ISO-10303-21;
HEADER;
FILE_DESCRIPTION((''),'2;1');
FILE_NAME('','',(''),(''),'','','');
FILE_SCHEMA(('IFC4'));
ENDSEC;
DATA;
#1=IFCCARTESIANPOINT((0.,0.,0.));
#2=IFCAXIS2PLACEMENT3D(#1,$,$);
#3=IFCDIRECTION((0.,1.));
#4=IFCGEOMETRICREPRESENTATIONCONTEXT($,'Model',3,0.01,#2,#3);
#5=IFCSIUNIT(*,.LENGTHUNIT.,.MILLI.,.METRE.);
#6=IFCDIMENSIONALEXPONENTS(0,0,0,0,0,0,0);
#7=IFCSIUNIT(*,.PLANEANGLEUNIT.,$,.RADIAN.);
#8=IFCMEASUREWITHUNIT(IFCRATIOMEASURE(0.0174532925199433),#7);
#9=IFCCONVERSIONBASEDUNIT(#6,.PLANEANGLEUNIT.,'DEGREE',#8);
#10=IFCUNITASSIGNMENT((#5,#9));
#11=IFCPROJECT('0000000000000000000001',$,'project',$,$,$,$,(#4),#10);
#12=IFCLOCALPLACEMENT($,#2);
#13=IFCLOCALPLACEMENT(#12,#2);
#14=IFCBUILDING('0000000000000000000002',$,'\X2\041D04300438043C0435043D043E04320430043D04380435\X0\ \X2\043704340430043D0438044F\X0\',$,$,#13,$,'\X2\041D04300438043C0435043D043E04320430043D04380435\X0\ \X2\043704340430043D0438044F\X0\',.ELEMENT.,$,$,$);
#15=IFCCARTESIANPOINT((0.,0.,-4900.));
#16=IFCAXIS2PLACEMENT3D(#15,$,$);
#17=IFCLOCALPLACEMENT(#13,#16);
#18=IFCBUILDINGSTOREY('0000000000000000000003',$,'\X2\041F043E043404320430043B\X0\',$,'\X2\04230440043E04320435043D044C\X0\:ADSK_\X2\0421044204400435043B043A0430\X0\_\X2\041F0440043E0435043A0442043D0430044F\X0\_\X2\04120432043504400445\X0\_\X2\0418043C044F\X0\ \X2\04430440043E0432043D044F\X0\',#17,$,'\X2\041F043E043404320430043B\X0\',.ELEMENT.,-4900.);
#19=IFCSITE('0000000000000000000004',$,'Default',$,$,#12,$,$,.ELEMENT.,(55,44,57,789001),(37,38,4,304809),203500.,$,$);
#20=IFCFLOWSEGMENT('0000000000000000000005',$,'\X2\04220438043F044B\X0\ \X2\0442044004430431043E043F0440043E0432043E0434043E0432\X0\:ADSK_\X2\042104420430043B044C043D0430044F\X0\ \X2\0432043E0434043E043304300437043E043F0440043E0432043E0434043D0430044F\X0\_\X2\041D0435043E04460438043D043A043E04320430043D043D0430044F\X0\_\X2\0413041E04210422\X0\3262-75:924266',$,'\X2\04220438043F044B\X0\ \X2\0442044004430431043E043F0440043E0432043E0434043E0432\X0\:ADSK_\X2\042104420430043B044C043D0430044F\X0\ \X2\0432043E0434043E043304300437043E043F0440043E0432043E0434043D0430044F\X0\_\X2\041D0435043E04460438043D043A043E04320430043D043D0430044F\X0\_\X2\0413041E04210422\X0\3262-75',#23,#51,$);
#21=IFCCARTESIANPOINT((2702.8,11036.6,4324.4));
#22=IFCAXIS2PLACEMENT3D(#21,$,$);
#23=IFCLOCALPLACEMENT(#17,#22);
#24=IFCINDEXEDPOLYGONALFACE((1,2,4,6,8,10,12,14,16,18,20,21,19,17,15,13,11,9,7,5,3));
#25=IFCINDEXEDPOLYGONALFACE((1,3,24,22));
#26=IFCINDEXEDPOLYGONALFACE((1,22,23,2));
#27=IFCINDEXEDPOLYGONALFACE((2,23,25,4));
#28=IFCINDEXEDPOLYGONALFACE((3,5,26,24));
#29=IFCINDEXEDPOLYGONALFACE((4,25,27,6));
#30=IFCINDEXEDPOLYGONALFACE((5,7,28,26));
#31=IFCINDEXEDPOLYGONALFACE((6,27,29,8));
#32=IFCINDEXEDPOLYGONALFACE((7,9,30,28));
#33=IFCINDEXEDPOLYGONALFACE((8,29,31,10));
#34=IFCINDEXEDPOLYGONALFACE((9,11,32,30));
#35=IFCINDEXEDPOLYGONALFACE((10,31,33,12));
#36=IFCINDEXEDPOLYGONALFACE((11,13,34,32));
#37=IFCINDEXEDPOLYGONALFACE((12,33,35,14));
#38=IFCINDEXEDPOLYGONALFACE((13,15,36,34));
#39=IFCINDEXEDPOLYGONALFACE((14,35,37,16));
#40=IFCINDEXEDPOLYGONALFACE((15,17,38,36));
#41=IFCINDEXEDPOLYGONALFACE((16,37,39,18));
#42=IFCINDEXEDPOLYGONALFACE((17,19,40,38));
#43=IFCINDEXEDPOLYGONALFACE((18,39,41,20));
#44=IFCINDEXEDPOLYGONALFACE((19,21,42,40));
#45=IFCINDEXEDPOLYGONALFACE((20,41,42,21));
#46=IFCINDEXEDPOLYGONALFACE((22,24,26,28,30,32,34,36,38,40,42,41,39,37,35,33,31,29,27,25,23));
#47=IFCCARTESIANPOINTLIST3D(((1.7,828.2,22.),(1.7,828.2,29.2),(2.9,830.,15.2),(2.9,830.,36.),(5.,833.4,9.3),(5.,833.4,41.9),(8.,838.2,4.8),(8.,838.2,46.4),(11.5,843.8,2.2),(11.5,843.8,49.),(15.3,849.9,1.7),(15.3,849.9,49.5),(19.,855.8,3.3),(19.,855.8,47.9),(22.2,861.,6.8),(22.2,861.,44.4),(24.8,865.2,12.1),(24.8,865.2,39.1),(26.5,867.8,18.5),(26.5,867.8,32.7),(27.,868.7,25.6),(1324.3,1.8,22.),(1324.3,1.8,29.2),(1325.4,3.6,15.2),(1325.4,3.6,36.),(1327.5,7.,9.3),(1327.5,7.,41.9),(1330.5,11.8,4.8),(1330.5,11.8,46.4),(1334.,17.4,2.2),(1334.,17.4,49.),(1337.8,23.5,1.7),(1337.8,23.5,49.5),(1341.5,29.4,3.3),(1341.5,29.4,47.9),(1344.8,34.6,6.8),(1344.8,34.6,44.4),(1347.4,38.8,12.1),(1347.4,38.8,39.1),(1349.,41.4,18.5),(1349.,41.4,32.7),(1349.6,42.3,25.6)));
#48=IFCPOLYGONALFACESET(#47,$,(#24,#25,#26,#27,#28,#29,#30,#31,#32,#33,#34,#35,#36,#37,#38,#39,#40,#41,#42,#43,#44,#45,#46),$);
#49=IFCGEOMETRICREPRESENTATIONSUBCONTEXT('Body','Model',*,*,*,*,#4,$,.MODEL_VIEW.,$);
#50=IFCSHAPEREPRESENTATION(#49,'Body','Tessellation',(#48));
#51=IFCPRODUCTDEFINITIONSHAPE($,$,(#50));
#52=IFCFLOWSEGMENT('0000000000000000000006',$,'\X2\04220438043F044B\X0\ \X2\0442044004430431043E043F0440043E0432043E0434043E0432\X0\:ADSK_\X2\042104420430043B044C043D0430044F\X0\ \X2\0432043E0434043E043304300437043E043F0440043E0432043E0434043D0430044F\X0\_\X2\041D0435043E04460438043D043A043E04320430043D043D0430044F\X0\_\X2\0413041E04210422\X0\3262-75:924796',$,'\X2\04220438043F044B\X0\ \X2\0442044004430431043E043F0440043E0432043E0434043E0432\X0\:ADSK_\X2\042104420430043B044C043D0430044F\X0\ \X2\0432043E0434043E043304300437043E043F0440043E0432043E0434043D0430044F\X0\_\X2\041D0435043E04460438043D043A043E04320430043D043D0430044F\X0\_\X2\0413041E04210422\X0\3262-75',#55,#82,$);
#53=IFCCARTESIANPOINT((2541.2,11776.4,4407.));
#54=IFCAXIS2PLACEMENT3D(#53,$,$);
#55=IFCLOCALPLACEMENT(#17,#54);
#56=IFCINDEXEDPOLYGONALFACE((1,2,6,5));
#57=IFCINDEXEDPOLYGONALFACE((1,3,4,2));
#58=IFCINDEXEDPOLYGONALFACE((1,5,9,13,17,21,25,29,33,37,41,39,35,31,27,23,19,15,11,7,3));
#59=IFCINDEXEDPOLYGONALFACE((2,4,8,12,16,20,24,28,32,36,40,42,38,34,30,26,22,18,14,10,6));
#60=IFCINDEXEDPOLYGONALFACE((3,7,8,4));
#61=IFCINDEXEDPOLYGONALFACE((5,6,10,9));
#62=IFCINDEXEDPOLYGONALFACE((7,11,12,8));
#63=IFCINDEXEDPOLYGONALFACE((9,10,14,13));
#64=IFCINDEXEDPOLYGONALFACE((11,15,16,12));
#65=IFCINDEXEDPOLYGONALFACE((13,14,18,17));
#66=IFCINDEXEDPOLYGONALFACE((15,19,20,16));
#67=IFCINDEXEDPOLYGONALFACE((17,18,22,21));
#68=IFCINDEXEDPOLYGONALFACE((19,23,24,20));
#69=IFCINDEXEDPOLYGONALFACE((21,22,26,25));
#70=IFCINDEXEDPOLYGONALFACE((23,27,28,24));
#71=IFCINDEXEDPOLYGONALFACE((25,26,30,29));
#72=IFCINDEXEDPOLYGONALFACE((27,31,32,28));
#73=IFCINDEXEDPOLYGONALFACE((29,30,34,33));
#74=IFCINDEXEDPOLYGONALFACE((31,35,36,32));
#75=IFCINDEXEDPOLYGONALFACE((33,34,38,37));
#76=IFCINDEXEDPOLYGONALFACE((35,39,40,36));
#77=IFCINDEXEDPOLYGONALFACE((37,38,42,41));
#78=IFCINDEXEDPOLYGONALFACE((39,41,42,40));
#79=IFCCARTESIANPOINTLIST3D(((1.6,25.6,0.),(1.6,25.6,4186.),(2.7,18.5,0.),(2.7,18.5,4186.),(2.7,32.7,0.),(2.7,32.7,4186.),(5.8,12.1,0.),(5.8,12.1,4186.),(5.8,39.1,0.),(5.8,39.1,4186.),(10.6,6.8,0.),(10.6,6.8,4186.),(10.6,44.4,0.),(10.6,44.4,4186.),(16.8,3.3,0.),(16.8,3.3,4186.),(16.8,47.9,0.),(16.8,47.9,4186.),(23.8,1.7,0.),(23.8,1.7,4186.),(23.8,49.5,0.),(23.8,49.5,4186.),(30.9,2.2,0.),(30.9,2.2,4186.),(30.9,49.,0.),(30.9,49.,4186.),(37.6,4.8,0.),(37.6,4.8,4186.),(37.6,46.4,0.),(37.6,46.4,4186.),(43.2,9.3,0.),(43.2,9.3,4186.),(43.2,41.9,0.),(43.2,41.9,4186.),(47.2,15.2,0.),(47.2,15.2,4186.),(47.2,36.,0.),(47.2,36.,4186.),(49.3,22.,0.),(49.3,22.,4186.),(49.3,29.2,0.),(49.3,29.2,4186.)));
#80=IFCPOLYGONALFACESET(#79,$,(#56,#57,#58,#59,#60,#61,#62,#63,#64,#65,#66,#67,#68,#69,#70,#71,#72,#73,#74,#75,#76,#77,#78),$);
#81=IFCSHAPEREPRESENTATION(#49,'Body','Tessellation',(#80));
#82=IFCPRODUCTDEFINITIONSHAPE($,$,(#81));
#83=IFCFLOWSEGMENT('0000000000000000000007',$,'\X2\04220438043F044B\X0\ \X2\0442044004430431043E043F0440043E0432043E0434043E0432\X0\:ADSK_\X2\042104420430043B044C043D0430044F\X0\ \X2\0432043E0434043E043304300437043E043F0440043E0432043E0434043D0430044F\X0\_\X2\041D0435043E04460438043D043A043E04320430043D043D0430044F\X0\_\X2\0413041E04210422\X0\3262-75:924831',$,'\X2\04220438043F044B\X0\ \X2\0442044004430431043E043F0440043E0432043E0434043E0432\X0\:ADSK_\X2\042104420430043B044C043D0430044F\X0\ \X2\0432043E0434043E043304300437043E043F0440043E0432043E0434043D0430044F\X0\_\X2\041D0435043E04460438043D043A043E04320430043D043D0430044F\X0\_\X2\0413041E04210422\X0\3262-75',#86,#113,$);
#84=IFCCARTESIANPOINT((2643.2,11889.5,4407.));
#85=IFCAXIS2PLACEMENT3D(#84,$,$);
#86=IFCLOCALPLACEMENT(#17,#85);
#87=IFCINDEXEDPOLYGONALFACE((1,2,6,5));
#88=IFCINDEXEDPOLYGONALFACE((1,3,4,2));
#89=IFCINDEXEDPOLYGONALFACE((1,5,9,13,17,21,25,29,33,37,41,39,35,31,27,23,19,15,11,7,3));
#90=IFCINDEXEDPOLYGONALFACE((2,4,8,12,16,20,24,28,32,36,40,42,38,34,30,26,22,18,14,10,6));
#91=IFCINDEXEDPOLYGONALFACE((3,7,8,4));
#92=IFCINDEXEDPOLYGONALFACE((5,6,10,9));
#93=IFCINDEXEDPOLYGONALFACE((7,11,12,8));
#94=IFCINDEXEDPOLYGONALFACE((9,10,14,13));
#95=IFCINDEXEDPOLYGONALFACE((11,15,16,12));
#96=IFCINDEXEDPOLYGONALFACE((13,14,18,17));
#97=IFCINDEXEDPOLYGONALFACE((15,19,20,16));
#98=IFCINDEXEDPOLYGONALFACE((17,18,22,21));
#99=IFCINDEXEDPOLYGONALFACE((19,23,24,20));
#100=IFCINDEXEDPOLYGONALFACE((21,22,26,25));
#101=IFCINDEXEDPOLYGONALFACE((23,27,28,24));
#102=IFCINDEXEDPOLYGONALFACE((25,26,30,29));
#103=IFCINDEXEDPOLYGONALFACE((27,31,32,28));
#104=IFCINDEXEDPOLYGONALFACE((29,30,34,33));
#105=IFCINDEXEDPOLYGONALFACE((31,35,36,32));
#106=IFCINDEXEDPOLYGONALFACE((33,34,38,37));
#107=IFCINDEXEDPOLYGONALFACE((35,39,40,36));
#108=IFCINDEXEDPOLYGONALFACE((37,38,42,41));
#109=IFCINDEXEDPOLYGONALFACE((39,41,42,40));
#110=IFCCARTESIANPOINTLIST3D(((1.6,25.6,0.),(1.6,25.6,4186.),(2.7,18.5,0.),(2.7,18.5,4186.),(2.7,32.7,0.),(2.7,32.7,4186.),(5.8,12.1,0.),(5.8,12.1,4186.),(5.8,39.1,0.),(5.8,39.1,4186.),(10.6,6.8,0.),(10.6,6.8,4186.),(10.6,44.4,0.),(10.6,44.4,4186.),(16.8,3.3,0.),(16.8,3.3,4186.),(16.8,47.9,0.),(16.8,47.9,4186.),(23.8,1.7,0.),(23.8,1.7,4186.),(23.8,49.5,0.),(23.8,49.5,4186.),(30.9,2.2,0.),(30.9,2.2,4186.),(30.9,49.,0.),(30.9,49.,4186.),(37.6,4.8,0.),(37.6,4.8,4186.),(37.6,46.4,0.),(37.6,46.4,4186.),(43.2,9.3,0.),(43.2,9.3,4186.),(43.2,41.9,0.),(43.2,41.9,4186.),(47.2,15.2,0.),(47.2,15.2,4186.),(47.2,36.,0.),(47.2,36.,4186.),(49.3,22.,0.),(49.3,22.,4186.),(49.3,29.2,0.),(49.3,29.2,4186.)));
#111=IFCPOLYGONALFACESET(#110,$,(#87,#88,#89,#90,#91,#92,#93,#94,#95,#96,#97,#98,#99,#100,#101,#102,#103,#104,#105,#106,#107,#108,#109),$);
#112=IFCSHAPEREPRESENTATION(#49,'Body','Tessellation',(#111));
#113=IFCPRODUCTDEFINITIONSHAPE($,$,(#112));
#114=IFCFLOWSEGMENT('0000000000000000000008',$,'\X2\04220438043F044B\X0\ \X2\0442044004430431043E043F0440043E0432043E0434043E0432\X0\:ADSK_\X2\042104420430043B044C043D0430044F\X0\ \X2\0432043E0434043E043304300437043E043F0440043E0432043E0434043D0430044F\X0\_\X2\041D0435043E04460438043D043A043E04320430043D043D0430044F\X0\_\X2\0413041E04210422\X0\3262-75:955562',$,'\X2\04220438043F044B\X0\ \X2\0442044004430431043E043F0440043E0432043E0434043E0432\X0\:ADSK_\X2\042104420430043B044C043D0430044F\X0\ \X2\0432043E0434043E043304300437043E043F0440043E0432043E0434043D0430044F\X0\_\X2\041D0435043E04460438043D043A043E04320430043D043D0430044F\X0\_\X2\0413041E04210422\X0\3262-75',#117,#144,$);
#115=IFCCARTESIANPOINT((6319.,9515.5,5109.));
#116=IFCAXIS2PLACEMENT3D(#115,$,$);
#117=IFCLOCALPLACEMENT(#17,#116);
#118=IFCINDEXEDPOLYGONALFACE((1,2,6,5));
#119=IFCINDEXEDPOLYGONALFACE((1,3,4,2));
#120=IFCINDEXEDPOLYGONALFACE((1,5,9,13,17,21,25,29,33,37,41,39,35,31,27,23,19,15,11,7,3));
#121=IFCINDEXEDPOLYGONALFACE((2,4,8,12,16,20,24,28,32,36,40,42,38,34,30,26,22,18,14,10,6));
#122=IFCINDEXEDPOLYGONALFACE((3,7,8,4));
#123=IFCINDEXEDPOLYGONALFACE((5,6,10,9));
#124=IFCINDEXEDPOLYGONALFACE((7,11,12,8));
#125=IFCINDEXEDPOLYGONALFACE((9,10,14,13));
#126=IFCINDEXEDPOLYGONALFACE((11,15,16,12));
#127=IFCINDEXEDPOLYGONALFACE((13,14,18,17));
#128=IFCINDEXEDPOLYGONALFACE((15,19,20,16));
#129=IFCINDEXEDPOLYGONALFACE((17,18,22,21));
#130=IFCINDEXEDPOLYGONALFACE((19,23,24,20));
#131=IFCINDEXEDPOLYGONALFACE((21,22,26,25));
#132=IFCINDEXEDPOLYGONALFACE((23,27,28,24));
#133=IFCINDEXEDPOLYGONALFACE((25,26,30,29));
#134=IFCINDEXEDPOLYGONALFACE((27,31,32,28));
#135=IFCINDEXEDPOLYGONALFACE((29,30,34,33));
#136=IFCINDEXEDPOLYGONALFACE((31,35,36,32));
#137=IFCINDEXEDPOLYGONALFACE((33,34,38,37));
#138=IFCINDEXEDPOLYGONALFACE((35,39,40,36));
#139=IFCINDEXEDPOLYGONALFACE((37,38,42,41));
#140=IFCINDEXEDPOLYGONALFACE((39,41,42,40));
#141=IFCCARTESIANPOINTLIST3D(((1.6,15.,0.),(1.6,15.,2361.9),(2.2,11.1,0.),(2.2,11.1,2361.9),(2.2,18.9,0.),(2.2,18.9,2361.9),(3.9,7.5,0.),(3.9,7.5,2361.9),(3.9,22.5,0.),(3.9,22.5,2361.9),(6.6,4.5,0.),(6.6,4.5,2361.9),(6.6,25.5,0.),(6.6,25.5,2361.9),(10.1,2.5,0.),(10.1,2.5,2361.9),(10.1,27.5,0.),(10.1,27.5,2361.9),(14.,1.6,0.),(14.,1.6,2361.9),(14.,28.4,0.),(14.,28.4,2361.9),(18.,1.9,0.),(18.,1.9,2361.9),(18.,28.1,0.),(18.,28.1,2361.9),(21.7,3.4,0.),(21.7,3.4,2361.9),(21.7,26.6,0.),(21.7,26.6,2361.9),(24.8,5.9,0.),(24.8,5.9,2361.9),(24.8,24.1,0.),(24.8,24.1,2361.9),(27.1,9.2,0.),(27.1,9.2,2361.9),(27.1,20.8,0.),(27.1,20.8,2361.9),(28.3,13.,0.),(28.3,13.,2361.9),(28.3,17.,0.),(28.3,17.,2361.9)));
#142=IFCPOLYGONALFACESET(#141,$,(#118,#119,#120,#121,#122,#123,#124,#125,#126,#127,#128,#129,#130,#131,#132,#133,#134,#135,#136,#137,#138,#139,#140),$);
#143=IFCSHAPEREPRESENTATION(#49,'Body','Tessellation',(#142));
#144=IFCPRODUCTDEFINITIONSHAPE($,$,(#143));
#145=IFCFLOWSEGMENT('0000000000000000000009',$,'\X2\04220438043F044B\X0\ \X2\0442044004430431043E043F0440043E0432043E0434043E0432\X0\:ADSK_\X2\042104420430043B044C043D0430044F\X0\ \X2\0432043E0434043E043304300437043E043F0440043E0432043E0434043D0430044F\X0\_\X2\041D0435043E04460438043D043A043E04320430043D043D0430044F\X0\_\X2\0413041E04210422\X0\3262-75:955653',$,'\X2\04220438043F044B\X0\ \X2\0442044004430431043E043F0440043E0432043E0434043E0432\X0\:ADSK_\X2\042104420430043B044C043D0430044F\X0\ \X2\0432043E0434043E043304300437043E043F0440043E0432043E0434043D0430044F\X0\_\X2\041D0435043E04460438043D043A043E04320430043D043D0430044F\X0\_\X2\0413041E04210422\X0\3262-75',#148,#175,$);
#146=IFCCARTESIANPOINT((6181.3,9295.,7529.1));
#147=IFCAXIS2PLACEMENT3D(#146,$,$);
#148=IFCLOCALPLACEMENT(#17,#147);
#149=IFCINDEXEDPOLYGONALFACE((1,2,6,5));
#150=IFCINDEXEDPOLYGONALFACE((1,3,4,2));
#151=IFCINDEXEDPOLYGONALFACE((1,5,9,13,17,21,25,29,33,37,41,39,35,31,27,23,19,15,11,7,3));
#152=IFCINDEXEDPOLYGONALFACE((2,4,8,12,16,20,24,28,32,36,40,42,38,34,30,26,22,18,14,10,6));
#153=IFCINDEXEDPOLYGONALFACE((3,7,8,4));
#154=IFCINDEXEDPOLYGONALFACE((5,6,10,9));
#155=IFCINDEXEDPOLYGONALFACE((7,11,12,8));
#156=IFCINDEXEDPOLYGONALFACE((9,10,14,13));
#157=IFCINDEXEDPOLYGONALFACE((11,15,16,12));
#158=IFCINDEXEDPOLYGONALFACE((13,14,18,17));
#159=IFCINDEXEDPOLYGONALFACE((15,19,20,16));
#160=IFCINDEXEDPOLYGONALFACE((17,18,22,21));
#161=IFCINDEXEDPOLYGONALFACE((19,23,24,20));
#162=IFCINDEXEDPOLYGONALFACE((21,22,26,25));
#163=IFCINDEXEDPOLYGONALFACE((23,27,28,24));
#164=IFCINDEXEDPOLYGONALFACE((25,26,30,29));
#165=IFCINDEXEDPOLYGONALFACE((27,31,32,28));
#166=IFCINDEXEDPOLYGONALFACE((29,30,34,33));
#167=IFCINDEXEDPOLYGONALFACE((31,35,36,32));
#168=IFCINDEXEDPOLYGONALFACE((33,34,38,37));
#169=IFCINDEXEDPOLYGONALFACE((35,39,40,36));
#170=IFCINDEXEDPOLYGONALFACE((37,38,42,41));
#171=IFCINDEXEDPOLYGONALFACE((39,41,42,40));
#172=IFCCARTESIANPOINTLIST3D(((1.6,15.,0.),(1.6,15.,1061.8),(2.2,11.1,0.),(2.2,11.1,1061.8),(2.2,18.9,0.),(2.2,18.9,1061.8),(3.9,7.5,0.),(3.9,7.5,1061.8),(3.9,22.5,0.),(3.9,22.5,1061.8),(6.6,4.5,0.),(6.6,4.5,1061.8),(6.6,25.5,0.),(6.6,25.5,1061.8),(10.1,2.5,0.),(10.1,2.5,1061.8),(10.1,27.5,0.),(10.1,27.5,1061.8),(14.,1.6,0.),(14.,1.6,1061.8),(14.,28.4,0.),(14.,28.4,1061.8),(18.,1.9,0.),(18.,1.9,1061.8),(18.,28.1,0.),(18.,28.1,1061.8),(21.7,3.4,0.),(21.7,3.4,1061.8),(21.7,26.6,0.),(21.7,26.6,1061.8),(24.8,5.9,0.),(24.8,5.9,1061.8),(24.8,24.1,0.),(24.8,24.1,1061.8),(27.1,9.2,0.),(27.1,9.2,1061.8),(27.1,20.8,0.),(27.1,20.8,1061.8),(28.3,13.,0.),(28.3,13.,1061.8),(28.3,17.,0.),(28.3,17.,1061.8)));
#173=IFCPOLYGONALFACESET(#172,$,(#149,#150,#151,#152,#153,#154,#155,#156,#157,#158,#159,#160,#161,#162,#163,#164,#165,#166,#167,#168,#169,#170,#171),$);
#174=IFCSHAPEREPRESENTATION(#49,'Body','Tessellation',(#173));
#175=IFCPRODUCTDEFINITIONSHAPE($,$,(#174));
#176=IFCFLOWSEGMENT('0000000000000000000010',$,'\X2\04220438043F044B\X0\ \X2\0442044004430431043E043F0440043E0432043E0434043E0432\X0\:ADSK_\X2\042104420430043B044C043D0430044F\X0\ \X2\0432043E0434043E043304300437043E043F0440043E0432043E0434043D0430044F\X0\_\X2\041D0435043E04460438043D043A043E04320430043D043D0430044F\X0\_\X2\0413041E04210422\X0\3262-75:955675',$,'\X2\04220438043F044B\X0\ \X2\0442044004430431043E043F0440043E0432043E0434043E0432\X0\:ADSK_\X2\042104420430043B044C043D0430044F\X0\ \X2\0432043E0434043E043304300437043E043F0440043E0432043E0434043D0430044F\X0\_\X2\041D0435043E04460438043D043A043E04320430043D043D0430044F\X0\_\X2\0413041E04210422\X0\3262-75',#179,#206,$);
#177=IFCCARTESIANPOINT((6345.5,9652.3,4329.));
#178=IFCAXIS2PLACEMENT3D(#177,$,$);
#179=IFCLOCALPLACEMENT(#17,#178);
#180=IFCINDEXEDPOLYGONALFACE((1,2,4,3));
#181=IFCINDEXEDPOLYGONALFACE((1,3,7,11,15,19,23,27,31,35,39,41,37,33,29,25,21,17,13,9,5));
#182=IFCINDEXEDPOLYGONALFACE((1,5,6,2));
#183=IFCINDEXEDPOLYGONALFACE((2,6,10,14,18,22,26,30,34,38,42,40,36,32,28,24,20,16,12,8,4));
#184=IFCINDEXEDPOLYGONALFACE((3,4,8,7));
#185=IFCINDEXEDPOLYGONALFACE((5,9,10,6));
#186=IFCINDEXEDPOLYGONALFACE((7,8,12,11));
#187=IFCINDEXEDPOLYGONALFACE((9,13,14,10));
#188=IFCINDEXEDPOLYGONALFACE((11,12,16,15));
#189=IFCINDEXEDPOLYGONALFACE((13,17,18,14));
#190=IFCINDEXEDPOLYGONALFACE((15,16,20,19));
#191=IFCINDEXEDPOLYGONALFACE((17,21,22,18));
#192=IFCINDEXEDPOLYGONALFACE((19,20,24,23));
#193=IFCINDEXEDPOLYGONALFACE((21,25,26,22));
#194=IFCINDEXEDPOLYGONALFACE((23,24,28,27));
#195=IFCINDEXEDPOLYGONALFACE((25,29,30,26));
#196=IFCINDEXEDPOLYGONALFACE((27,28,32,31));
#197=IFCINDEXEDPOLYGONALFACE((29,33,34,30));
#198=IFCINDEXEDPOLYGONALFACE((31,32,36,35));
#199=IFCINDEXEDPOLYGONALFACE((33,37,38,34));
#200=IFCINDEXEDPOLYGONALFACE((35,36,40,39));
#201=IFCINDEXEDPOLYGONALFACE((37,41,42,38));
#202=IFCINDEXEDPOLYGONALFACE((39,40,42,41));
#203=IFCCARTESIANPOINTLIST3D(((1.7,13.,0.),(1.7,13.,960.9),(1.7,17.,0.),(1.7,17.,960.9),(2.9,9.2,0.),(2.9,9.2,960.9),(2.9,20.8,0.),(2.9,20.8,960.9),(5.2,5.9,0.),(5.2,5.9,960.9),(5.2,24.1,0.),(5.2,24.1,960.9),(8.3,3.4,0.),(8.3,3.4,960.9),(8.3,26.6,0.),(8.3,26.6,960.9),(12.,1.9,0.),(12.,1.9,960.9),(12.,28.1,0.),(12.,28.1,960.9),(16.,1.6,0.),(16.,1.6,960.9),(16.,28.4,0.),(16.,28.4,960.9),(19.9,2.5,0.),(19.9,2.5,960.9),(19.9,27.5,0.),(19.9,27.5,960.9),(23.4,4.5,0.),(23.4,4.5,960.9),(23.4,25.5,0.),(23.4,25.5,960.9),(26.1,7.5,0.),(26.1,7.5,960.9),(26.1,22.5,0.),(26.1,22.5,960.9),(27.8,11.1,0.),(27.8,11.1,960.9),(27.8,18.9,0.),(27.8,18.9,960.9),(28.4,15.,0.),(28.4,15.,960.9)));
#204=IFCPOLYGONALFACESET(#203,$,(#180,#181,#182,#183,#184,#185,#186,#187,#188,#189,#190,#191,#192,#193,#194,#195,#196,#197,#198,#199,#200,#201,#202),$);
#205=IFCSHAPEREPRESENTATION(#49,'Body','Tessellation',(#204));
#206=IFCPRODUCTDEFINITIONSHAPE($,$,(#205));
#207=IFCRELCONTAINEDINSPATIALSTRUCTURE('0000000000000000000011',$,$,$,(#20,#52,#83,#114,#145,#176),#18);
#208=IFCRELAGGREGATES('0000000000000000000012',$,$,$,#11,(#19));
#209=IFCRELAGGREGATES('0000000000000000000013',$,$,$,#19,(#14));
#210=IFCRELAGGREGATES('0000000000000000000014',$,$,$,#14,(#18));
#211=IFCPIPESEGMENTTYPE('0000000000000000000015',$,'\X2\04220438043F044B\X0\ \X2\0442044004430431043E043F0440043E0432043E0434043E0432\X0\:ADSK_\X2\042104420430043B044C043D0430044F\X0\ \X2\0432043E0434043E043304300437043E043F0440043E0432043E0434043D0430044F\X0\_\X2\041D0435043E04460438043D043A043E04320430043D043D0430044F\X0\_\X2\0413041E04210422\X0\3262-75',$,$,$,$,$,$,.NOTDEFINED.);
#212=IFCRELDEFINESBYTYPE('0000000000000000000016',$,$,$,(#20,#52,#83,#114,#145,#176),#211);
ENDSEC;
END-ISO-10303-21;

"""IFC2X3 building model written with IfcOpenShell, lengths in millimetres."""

from ifc_helpers import new_model, entity, si_unit, converted_unit, direction, frame, origin, origin_2d_with_axis, place, context, subcontext, project, spatial, circle, extrude, type_object, element, save


model = new_model("IFC2X3")

# Units and contexts
model_context = context("Model", 3, precision=0.01, world=origin(), true_north=direction((0.0, 1.0)))
body_context = subcontext(model_context, "Body", "Model", "MODEL_VIEW")
ifc_project = project(units=[si_unit("LENGTHUNIT", "METRE", prefix="MILLI"), converted_unit("PLANEANGLEUNIT", "DEGREE", entity("IfcRatioMeasure", 0.0174532925199433), si_unit("PLANEANGLEUNIT", "RADIAN"), dimensions=[0, 0, 0, 0, 0, 0, 0])], contexts=[model_context])

# Site, building, storey
site_placement = place(None, origin())
site = spatial("IfcSite", under=ifc_project, at=site_placement, Name="Default", CompositionType="ELEMENT", RefLatitude=(55, 44, 57, 789001), RefLongitude=(37, 38, 4, 304809), RefElevation=203500.0)
building_placement = place(site_placement, origin())
building = spatial("IfcBuilding", under=site, at=building_placement, Name="Наименование здания", LongName="Наименование здания", CompositionType="ELEMENT")
storey_placement = place(building_placement, frame((0.0, 0.0, -4900.0)))
storey = spatial("IfcBuildingStorey", under=building, at=storey_placement, Name="Подвал", ObjectType="Уровень:ADSK_Стрелка_Проектная_Вверх_Имя уровня", LongName="Подвал", CompositionType="ELEMENT", Elevation=-4900.0)

# Flow segments
pipe_segment_type = type_object("IfcPipeSegmentType", Name="Типы трубопроводов:ADSK_Стальная водогазопроводная_Неоцинкованная_ГОСТ3262-75", PredefinedType="NOTDEFINED")
flow_segment_1_placement = place(storey_placement, frame((2702.8, 11036.6, 4324.4)))
element("IfcFlowSegment", 1, at=flow_segment_1_placement, inside=storey, type_object=pipe_segment_type, Name="Типы трубопроводов:ADSK_Стальная водогазопроводная_Неоцинкованная_ГОСТ3262-75:924266", ObjectType="Типы трубопроводов:ADSK_Стальная водогазопроводная_Неоцинкованная_ГОСТ3262-75", context=body_context, shape_type="SweptSolid", body=[
    extrude(circle(Radius=24.0, at=origin_2d_with_axis()), frame((14.3, 848.4, 25.6), z_axis=(0.848053, -0.529912, 0.0), x_axis=(0.529912, 0.848053, 0.0)), (0.0, 0.0, 1.0), 1559.5),
])
for number, where, name in (
    (2, (2541.2, 11776.4, 4407.0), "Типы трубопроводов:ADSK_Стальная водогазопроводная_Неоцинкованная_ГОСТ3262-75:924796"),
    (3, (2643.2, 11889.5, 4407.0), "Типы трубопроводов:ADSK_Стальная водогазопроводная_Неоцинкованная_ГОСТ3262-75:924831"),
):
    element("IfcFlowSegment", number, at=place(storey_placement, frame(where)), inside=storey, type_object=pipe_segment_type, Name=name, ObjectType="Типы трубопроводов:ADSK_Стальная водогазопроводная_Неоцинкованная_ГОСТ3262-75", context=body_context, shape_type="SweptSolid", body=[
        extrude(circle(Radius=24.0, at=origin_2d_with_axis()), frame((25.6, 25.6, 0.0), z_axis=(0.0, 0.0, 1.0), x_axis=(-1.0, 0.0, 0.0)), (0.0, 0.0, 1.0), 4186.0),
    ])
flow_segment_2_placement = place(storey_placement, frame((6319.0, 9515.5, 5109.0)))
element("IfcFlowSegment", 4, at=flow_segment_2_placement, inside=storey, type_object=pipe_segment_type, Name="Типы трубопроводов:ADSK_Стальная водогазопроводная_Неоцинкованная_ГОСТ3262-75:955562", ObjectType="Типы трубопроводов:ADSK_Стальная водогазопроводная_Неоцинкованная_ГОСТ3262-75", context=body_context, shape_type="SweptSolid", body=[
    extrude(circle(Radius=13.4, at=origin_2d_with_axis()), frame((15.0, 15.0, 0.0), z_axis=(0.0, 0.0, 1.0), x_axis=(-1.0, 0.0, 0.0)), (0.0, 0.0, 1.0), 2361.9),
])
flow_segment_3_placement = place(storey_placement, frame((6181.3, 9295.0, 7529.1)))
element("IfcFlowSegment", 5, at=flow_segment_3_placement, inside=storey, type_object=pipe_segment_type, Name="Типы трубопроводов:ADSK_Стальная водогазопроводная_Неоцинкованная_ГОСТ3262-75:955653", ObjectType="Типы трубопроводов:ADSK_Стальная водогазопроводная_Неоцинкованная_ГОСТ3262-75", context=body_context, shape_type="SweptSolid", body=[
    extrude(circle(Radius=13.4, at=origin_2d_with_axis()), frame((15.0, 15.0, 0.0), z_axis=(0.0, 0.0, 1.0), x_axis=(-1.0, 0.0, 0.0)), (0.0, 0.0, 1.0), 1061.8),
])
flow_segment_4_placement = place(storey_placement, frame((6345.5, 9652.3, 4329.0)))
element("IfcFlowSegment", 6, at=flow_segment_4_placement, inside=storey, type_object=pipe_segment_type, Name="Типы трубопроводов:ADSK_Стальная водогазопроводная_Неоцинкованная_ГОСТ3262-75:955675", ObjectType="Типы трубопроводов:ADSK_Стальная водогазопроводная_Неоцинкованная_ГОСТ3262-75", context=body_context, shape_type="SweptSolid", body=[
    extrude(circle(Radius=13.4, at=origin_2d_with_axis()), frame((15.0, 15.0, 0.0)), (0.0, 0.0, 1.0), 960.9),
])

save(model, "model.ifc")
